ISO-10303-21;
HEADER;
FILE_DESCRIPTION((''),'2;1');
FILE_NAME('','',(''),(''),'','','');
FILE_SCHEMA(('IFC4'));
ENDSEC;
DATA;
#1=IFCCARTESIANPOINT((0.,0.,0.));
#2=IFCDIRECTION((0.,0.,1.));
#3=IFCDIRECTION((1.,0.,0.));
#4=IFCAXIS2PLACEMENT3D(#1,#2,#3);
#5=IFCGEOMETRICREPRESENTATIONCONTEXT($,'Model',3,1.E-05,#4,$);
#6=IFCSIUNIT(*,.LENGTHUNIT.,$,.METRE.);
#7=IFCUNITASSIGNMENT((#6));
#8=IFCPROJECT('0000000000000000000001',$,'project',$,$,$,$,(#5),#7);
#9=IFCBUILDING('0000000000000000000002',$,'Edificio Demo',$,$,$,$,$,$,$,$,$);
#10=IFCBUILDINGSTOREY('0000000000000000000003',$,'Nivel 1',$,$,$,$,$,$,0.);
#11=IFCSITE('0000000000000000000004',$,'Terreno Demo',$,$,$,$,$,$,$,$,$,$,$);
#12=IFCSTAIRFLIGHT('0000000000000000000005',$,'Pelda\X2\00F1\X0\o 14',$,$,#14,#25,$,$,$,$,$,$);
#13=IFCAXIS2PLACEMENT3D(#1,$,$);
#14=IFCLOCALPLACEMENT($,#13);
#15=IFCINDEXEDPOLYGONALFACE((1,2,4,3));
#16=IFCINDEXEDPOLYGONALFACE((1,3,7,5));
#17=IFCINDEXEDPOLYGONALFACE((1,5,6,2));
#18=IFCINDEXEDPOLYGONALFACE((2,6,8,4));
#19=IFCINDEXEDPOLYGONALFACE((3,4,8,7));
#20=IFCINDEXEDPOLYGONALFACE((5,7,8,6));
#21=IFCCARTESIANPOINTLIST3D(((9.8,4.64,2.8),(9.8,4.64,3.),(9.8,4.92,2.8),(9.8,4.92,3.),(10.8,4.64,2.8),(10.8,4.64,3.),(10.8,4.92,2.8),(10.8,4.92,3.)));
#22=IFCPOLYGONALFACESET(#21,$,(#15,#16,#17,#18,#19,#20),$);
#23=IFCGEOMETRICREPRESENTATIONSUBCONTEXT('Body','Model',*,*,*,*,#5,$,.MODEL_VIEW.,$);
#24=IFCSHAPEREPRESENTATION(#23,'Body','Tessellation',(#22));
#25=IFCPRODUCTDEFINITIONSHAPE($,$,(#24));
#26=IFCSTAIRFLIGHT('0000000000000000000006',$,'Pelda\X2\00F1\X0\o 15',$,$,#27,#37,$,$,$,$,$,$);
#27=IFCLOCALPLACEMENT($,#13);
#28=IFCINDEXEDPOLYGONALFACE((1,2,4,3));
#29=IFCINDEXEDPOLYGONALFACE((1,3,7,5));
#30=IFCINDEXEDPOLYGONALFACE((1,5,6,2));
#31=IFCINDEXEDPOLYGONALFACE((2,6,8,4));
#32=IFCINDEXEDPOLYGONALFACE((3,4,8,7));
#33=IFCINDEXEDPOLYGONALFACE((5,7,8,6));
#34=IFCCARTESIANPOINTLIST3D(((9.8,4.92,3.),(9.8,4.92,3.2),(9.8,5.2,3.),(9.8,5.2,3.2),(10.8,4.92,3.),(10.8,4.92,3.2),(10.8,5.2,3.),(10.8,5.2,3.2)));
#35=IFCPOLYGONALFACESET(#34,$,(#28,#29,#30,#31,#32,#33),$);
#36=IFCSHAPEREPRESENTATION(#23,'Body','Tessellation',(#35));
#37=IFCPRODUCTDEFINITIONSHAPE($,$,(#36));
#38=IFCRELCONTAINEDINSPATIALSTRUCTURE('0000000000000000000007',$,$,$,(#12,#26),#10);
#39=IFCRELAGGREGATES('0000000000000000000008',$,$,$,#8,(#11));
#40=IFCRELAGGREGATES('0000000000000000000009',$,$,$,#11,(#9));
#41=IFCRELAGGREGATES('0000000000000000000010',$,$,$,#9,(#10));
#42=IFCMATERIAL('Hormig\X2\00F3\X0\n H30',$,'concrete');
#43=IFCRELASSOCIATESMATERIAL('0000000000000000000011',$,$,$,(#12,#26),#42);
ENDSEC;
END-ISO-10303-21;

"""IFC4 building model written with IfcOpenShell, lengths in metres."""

from ifc_helpers import new_model, si_unit, frame, frame_2d, origin_with_axes, place, context, subcontext, project, spatial, rectangle, extrude, material, element, save


model = new_model("IFC4")

# Units and contexts
model_context = context("Model", 3, precision=1e-05, world=origin_with_axes())
body_context = subcontext(model_context, "Body", "Model", "MODEL_VIEW")
ifc_project = project(units=[si_unit("LENGTHUNIT", "METRE")], contexts=[model_context])

# Site, building, storey
site = spatial("IfcSite", under=ifc_project, Name="Terreno Demo")
building = spatial("IfcBuilding", under=site, Name="Edificio Demo")
storey = spatial("IfcBuildingStorey", under=building, Name="Nivel 1", Elevation=0.0)

# Shared definitions
ifc_material_1 = material(Name="Hormigón H30", Category="concrete")

# Stair flights
for number, where, z_axis, x_axis, name in (
    (1, (9.8, 4.64, 2.8), (0.0, 0.0, 1.0), (1.0, 0.0, 0.0), "Peldaño 14"),
    (2, (9.8, 4.92, 3.0), (0.0, 0.0, 1.0), (1.0, 0.0, 0.0), "Peldaño 15"),
):
    element("IfcStairFlight", number, at=place(None, frame(where, z_axis=z_axis, x_axis=x_axis)), inside=storey, material=ifc_material_1, Name=name, context=body_context, shape_type="SweptSolid", body=[
        extrude(rectangle(XDim=1.0, YDim=0.28, at=frame_2d((0.5, 0.14))), origin_with_axes(), (0.0, 0.0, 1.0), 0.2),
    ])

save(model, "model.ifc")
